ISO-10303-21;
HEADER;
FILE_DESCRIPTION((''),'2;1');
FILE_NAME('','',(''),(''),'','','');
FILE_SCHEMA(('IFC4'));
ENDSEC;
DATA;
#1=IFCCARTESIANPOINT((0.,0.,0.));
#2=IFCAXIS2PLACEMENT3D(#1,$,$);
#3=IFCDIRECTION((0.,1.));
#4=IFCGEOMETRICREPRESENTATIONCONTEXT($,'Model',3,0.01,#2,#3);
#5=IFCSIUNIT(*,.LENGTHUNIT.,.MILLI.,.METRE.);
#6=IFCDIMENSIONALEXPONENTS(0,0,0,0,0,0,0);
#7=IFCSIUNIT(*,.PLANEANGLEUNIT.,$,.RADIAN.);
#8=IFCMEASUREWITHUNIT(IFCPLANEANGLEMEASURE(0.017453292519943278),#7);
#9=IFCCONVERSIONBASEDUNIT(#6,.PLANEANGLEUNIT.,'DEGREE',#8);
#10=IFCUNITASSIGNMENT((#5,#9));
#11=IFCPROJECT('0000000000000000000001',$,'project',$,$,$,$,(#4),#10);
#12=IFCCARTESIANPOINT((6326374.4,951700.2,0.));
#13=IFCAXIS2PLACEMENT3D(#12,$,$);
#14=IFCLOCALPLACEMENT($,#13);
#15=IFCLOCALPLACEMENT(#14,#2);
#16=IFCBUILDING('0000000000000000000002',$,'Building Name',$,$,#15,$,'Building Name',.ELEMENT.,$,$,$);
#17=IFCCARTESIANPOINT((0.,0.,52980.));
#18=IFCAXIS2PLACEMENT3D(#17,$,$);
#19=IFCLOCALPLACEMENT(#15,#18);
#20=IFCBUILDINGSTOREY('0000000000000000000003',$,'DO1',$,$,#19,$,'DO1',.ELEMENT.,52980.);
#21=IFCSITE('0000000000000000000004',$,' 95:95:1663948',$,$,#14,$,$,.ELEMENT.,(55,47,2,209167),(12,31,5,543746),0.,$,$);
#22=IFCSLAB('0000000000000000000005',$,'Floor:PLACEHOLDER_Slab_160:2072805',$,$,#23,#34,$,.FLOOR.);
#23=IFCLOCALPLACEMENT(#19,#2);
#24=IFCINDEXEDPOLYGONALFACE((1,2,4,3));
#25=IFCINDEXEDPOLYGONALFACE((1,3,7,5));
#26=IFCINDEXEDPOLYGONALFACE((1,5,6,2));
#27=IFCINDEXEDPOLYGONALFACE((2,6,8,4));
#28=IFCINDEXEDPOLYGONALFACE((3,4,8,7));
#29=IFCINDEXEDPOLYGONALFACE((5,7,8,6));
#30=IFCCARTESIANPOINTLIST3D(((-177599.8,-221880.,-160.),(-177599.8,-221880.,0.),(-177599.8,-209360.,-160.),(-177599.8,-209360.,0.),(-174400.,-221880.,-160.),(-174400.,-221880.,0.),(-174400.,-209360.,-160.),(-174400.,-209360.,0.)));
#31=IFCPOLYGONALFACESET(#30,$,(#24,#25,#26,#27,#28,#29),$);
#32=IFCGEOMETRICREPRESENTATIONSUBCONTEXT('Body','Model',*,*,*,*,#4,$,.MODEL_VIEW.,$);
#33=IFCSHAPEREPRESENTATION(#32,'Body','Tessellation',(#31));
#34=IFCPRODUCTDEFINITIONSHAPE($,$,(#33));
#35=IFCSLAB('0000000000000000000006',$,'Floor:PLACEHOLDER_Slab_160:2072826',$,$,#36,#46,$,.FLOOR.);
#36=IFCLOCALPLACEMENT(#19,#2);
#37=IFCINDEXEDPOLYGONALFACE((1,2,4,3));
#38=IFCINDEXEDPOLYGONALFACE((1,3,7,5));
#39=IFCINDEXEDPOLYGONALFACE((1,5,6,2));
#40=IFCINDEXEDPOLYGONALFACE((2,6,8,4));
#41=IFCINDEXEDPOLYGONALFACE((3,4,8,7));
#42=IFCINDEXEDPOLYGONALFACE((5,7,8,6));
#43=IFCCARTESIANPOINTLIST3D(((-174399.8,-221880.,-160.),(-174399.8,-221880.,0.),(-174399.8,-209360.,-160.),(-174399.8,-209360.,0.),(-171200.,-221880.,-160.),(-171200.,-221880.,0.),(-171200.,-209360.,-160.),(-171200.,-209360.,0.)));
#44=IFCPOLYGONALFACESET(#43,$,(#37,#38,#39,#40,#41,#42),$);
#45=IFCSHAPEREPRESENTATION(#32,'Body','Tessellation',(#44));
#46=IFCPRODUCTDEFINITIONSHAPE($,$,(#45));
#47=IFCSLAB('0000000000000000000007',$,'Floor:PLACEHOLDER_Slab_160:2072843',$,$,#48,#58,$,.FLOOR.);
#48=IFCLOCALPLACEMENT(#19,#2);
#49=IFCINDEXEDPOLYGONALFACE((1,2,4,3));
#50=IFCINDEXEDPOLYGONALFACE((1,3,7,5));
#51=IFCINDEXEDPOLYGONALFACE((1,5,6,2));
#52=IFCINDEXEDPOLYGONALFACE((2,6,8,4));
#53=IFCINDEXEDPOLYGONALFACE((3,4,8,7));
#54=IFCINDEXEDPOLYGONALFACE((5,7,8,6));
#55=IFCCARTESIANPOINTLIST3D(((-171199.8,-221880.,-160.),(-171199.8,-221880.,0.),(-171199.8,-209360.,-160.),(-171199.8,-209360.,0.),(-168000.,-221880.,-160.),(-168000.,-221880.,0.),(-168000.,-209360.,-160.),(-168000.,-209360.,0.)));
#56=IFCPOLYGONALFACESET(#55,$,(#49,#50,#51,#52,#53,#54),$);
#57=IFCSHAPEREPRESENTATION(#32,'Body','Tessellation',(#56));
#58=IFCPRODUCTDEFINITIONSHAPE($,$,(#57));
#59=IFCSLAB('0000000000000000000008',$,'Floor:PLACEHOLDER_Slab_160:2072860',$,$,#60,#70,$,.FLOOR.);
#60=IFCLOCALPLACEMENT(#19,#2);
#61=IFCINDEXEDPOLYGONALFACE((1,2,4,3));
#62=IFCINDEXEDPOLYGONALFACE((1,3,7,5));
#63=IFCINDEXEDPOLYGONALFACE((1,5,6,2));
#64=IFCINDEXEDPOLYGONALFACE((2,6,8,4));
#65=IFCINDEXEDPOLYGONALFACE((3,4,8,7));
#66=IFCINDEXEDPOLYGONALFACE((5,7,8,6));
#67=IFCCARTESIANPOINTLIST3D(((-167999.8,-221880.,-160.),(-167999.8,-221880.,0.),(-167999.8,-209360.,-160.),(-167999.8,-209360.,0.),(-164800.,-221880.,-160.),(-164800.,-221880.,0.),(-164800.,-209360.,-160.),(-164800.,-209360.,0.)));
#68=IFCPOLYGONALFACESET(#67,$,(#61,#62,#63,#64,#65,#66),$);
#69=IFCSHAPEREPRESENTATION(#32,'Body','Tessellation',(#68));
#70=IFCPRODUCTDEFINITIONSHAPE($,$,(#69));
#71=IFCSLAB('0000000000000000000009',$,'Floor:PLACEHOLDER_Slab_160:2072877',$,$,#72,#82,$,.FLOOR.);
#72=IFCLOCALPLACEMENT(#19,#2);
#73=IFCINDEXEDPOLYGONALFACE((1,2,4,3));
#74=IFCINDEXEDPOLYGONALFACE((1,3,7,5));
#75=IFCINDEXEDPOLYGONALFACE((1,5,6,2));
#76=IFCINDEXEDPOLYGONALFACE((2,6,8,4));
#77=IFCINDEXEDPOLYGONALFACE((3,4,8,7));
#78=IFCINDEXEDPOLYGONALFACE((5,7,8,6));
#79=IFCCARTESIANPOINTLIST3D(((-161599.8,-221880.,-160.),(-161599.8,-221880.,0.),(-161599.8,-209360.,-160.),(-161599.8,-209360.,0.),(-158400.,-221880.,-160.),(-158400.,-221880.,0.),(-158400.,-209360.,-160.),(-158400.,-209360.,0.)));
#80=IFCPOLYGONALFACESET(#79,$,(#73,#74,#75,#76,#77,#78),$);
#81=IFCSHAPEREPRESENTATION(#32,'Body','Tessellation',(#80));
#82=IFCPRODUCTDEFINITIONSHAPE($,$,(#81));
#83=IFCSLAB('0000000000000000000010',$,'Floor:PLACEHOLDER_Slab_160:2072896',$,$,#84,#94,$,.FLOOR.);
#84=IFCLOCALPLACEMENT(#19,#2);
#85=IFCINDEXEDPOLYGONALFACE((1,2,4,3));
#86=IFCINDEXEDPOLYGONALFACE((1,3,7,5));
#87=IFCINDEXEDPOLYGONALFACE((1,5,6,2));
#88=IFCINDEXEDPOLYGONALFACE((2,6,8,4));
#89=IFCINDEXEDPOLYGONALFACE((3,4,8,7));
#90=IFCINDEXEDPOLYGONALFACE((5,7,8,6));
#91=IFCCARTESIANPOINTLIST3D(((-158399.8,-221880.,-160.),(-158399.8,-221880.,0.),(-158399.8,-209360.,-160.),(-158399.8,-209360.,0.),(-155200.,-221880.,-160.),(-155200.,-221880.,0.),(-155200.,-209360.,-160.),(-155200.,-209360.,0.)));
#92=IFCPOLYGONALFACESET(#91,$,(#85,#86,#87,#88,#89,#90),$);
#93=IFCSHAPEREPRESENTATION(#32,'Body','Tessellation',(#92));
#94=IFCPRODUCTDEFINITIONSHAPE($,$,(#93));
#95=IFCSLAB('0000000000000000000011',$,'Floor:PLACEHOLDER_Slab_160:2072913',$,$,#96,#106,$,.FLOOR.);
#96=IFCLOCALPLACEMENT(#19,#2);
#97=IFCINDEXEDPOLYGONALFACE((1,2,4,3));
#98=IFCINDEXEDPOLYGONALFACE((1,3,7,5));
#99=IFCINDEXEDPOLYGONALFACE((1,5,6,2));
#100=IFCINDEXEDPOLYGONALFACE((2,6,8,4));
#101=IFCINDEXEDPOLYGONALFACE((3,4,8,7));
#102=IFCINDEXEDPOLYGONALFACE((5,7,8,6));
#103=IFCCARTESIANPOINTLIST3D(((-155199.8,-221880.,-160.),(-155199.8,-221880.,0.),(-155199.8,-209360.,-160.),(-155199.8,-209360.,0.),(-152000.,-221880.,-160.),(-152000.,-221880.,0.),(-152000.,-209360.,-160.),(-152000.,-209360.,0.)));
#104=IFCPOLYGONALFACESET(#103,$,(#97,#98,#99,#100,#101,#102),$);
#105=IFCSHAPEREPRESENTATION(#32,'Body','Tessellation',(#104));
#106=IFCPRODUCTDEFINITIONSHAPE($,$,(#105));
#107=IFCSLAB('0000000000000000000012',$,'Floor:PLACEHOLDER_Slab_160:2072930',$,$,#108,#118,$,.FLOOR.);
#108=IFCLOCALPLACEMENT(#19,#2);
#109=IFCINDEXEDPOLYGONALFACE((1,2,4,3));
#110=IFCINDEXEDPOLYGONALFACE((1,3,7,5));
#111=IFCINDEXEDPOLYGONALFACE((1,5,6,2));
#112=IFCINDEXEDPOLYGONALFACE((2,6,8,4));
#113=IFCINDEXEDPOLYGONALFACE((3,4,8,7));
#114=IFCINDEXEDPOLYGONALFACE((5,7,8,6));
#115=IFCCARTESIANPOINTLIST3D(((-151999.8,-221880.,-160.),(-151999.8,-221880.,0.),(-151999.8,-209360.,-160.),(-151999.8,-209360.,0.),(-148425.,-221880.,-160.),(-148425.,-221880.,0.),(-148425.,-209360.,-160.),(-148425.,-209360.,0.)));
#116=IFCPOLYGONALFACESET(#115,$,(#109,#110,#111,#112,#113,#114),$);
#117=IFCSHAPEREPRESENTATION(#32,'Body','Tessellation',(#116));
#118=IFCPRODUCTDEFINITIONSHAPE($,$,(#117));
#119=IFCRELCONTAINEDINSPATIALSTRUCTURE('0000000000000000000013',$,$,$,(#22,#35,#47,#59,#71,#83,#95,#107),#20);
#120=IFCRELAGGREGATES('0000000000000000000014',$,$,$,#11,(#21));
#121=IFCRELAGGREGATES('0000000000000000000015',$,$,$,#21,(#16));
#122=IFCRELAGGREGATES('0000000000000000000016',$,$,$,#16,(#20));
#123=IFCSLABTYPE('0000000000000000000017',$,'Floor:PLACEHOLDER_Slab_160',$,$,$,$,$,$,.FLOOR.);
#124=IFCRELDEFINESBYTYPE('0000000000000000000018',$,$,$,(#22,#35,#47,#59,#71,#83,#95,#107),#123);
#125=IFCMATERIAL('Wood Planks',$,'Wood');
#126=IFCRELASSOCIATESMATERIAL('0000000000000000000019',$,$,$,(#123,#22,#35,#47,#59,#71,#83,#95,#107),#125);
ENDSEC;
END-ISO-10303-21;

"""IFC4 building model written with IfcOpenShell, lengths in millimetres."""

from ifc_helpers import new_model, entity, si_unit, converted_unit, direction, frame, origin, place, context, subcontext, project, spatial, indexed_curve, outline, extrude, material, type_object, element, save


model = new_model("IFC4")

# Units and contexts
model_context = context("Model", 3, precision=0.01, world=origin(), true_north=direction((0.0, 1.0)))
body_context = subcontext(model_context, "Body", "Model", "MODEL_VIEW")
ifc_project = project(units=[si_unit("LENGTHUNIT", "METRE", prefix="MILLI"), converted_unit("PLANEANGLEUNIT", "DEGREE", entity("IfcPlaneAngleMeasure", 0.017453292519943278), si_unit("PLANEANGLEUNIT", "RADIAN"), dimensions=[0, 0, 0, 0, 0, 0, 0])], contexts=[model_context])

# Site, building, storey
site_placement = place(None, frame((6326374.4, 951700.2, 0.0)))
site = spatial("IfcSite", under=ifc_project, at=site_placement, Name=" 95:95:1663948", CompositionType="ELEMENT", RefLatitude=(55, 47, 2, 209167), RefLongitude=(12, 31, 5, 543746), RefElevation=0.0)
building_placement = place(site_placement, origin())
building = spatial("IfcBuilding", under=site, at=building_placement, Name="Building Name", LongName="Building Name", CompositionType="ELEMENT")
storey_placement = place(building_placement, frame((0.0, 0.0, 52980.0)))
storey = spatial("IfcBuildingStorey", under=building, at=storey_placement, Name="DO1", LongName="DO1", CompositionType="ELEMENT", Elevation=52980.0)

# Slabs
ifc_material = material(Name="Wood Planks", Category="Wood")
slab_type = type_object("IfcSlabType", Name="Floor:PLACEHOLDER_Slab_160", PredefinedType="FLOOR", material=ifc_material)
slab_1_placement = place(storey_placement, origin())
element("IfcSlab", 1, at=slab_1_placement, inside=storey, type_object=slab_type, material=ifc_material, Name="Floor:PLACEHOLDER_Slab_160:2072805", PredefinedType="FLOOR", context=body_context, shape_type="SweptSolid", body=[
    extrude(outline(indexed_curve([(-6260.0, -1599.9), (6260.0, -1599.9), (6260.0, 1599.9), (-6260.0, 1599.9), (-6260.0, -1599.9)], self_intersect=False)), frame((-175999.9, -215620.0, 0.0), z_axis=(0.0, 0.0, -1.0), x_axis=(0.0, 1.0, 0.0)), (0.0, 0.0, 1.0), 160.0),
])
slab_2_placement = place(storey_placement, origin())
element("IfcSlab", 2, at=slab_2_placement, inside=storey, type_object=slab_type, material=ifc_material, Name="Floor:PLACEHOLDER_Slab_160:2072826", PredefinedType="FLOOR", context=body_context, shape_type="SweptSolid", body=[
    extrude(outline(indexed_curve([(-6260.0, -1599.9), (6260.0, -1599.9), (6260.0, 1599.9), (-6260.0, 1599.9), (-6260.0, -1599.9)], self_intersect=False)), frame((-172799.9, -215620.0, 0.0), z_axis=(0.0, 0.0, -1.0), x_axis=(0.0, 1.0, 0.0)), (0.0, 0.0, 1.0), 160.0),
])
slab_3_placement = place(storey_placement, origin())
element("IfcSlab", 3, at=slab_3_placement, inside=storey, type_object=slab_type, material=ifc_material, Name="Floor:PLACEHOLDER_Slab_160:2072843", PredefinedType="FLOOR", context=body_context, shape_type="SweptSolid", body=[
    extrude(outline(indexed_curve([(-6260.0, -1599.9), (6260.0, -1599.9), (6260.0, 1599.9), (-6260.0, 1599.9), (-6260.0, -1599.9)], self_intersect=False)), frame((-169599.9, -215620.0, 0.0), z_axis=(0.0, 0.0, -1.0), x_axis=(0.0, 1.0, 0.0)), (0.0, 0.0, 1.0), 160.0),
])
slab_4_placement = place(storey_placement, origin())
element("IfcSlab", 4, at=slab_4_placement, inside=storey, type_object=slab_type, material=ifc_material, Name="Floor:PLACEHOLDER_Slab_160:2072860", PredefinedType="FLOOR", context=body_context, shape_type="SweptSolid", body=[
    extrude(outline(indexed_curve([(-6260.0, -1599.9), (6260.0, -1599.9), (6260.0, 1599.9), (-6260.0, 1599.9), (-6260.0, -1599.9)], self_intersect=False)), frame((-166399.9, -215620.0, 0.0), z_axis=(0.0, 0.0, -1.0), x_axis=(0.0, 1.0, 0.0)), (0.0, 0.0, 1.0), 160.0),
])
slab_5_placement = place(storey_placement, origin())
element("IfcSlab", 5, at=slab_5_placement, inside=storey, type_object=slab_type, material=ifc_material, Name="Floor:PLACEHOLDER_Slab_160:2072877", PredefinedType="FLOOR", context=body_context, shape_type="SweptSolid", body=[
    extrude(outline(indexed_curve([(-6260.0, -1599.9), (6260.0, -1599.9), (6260.0, 1599.9), (-6260.0, 1599.9), (-6260.0, -1599.9)], self_intersect=False)), frame((-159999.9, -215620.0, 0.0), z_axis=(0.0, 0.0, -1.0), x_axis=(0.0, 1.0, 0.0)), (0.0, 0.0, 1.0), 160.0),
])
slab_6_placement = place(storey_placement, origin())
element("IfcSlab", 6, at=slab_6_placement, inside=storey, type_object=slab_type, material=ifc_material, Name="Floor:PLACEHOLDER_Slab_160:2072896", PredefinedType="FLOOR", context=body_context, shape_type="SweptSolid", body=[
    extrude(outline(indexed_curve([(-6260.0, -1599.9), (6260.0, -1599.9), (6260.0, 1599.9), (-6260.0, 1599.9), (-6260.0, -1599.9)], self_intersect=False)), frame((-156799.9, -215620.0, 0.0), z_axis=(0.0, 0.0, -1.0), x_axis=(0.0, 1.0, 0.0)), (0.0, 0.0, 1.0), 160.0),
])
slab_7_placement = place(storey_placement, origin())
element("IfcSlab", 7, at=slab_7_placement, inside=storey, type_object=slab_type, material=ifc_material, Name="Floor:PLACEHOLDER_Slab_160:2072913", PredefinedType="FLOOR", context=body_context, shape_type="SweptSolid", body=[
    extrude(outline(indexed_curve([(-6260.0, -1599.9), (6260.0, -1599.9), (6260.0, 1599.9), (-6260.0, 1599.9), (-6260.0, -1599.9)], self_intersect=False)), frame((-153599.9, -215620.0, 0.0), z_axis=(0.0, 0.0, -1.0), x_axis=(0.0, 1.0, 0.0)), (0.0, 0.0, 1.0), 160.0),
])
slab_8_placement = place(storey_placement, origin())
element("IfcSlab", 8, at=slab_8_placement, inside=storey, type_object=slab_type, material=ifc_material, Name="Floor:PLACEHOLDER_Slab_160:2072930", PredefinedType="FLOOR", context=body_context, shape_type="SweptSolid", body=[
    extrude(outline(indexed_curve([(-6260.0, -1787.4), (6260.0, -1787.4), (6260.0, 1787.4), (-6260.0, 1787.4), (-6260.0, -1787.4)], self_intersect=False)), frame((-150212.4, -215620.0, 0.0), z_axis=(0.0, 0.0, -1.0), x_axis=(0.0, 1.0, 0.0)), (0.0, 0.0, 1.0), 160.0),
])

save(model, "model.ifc")
